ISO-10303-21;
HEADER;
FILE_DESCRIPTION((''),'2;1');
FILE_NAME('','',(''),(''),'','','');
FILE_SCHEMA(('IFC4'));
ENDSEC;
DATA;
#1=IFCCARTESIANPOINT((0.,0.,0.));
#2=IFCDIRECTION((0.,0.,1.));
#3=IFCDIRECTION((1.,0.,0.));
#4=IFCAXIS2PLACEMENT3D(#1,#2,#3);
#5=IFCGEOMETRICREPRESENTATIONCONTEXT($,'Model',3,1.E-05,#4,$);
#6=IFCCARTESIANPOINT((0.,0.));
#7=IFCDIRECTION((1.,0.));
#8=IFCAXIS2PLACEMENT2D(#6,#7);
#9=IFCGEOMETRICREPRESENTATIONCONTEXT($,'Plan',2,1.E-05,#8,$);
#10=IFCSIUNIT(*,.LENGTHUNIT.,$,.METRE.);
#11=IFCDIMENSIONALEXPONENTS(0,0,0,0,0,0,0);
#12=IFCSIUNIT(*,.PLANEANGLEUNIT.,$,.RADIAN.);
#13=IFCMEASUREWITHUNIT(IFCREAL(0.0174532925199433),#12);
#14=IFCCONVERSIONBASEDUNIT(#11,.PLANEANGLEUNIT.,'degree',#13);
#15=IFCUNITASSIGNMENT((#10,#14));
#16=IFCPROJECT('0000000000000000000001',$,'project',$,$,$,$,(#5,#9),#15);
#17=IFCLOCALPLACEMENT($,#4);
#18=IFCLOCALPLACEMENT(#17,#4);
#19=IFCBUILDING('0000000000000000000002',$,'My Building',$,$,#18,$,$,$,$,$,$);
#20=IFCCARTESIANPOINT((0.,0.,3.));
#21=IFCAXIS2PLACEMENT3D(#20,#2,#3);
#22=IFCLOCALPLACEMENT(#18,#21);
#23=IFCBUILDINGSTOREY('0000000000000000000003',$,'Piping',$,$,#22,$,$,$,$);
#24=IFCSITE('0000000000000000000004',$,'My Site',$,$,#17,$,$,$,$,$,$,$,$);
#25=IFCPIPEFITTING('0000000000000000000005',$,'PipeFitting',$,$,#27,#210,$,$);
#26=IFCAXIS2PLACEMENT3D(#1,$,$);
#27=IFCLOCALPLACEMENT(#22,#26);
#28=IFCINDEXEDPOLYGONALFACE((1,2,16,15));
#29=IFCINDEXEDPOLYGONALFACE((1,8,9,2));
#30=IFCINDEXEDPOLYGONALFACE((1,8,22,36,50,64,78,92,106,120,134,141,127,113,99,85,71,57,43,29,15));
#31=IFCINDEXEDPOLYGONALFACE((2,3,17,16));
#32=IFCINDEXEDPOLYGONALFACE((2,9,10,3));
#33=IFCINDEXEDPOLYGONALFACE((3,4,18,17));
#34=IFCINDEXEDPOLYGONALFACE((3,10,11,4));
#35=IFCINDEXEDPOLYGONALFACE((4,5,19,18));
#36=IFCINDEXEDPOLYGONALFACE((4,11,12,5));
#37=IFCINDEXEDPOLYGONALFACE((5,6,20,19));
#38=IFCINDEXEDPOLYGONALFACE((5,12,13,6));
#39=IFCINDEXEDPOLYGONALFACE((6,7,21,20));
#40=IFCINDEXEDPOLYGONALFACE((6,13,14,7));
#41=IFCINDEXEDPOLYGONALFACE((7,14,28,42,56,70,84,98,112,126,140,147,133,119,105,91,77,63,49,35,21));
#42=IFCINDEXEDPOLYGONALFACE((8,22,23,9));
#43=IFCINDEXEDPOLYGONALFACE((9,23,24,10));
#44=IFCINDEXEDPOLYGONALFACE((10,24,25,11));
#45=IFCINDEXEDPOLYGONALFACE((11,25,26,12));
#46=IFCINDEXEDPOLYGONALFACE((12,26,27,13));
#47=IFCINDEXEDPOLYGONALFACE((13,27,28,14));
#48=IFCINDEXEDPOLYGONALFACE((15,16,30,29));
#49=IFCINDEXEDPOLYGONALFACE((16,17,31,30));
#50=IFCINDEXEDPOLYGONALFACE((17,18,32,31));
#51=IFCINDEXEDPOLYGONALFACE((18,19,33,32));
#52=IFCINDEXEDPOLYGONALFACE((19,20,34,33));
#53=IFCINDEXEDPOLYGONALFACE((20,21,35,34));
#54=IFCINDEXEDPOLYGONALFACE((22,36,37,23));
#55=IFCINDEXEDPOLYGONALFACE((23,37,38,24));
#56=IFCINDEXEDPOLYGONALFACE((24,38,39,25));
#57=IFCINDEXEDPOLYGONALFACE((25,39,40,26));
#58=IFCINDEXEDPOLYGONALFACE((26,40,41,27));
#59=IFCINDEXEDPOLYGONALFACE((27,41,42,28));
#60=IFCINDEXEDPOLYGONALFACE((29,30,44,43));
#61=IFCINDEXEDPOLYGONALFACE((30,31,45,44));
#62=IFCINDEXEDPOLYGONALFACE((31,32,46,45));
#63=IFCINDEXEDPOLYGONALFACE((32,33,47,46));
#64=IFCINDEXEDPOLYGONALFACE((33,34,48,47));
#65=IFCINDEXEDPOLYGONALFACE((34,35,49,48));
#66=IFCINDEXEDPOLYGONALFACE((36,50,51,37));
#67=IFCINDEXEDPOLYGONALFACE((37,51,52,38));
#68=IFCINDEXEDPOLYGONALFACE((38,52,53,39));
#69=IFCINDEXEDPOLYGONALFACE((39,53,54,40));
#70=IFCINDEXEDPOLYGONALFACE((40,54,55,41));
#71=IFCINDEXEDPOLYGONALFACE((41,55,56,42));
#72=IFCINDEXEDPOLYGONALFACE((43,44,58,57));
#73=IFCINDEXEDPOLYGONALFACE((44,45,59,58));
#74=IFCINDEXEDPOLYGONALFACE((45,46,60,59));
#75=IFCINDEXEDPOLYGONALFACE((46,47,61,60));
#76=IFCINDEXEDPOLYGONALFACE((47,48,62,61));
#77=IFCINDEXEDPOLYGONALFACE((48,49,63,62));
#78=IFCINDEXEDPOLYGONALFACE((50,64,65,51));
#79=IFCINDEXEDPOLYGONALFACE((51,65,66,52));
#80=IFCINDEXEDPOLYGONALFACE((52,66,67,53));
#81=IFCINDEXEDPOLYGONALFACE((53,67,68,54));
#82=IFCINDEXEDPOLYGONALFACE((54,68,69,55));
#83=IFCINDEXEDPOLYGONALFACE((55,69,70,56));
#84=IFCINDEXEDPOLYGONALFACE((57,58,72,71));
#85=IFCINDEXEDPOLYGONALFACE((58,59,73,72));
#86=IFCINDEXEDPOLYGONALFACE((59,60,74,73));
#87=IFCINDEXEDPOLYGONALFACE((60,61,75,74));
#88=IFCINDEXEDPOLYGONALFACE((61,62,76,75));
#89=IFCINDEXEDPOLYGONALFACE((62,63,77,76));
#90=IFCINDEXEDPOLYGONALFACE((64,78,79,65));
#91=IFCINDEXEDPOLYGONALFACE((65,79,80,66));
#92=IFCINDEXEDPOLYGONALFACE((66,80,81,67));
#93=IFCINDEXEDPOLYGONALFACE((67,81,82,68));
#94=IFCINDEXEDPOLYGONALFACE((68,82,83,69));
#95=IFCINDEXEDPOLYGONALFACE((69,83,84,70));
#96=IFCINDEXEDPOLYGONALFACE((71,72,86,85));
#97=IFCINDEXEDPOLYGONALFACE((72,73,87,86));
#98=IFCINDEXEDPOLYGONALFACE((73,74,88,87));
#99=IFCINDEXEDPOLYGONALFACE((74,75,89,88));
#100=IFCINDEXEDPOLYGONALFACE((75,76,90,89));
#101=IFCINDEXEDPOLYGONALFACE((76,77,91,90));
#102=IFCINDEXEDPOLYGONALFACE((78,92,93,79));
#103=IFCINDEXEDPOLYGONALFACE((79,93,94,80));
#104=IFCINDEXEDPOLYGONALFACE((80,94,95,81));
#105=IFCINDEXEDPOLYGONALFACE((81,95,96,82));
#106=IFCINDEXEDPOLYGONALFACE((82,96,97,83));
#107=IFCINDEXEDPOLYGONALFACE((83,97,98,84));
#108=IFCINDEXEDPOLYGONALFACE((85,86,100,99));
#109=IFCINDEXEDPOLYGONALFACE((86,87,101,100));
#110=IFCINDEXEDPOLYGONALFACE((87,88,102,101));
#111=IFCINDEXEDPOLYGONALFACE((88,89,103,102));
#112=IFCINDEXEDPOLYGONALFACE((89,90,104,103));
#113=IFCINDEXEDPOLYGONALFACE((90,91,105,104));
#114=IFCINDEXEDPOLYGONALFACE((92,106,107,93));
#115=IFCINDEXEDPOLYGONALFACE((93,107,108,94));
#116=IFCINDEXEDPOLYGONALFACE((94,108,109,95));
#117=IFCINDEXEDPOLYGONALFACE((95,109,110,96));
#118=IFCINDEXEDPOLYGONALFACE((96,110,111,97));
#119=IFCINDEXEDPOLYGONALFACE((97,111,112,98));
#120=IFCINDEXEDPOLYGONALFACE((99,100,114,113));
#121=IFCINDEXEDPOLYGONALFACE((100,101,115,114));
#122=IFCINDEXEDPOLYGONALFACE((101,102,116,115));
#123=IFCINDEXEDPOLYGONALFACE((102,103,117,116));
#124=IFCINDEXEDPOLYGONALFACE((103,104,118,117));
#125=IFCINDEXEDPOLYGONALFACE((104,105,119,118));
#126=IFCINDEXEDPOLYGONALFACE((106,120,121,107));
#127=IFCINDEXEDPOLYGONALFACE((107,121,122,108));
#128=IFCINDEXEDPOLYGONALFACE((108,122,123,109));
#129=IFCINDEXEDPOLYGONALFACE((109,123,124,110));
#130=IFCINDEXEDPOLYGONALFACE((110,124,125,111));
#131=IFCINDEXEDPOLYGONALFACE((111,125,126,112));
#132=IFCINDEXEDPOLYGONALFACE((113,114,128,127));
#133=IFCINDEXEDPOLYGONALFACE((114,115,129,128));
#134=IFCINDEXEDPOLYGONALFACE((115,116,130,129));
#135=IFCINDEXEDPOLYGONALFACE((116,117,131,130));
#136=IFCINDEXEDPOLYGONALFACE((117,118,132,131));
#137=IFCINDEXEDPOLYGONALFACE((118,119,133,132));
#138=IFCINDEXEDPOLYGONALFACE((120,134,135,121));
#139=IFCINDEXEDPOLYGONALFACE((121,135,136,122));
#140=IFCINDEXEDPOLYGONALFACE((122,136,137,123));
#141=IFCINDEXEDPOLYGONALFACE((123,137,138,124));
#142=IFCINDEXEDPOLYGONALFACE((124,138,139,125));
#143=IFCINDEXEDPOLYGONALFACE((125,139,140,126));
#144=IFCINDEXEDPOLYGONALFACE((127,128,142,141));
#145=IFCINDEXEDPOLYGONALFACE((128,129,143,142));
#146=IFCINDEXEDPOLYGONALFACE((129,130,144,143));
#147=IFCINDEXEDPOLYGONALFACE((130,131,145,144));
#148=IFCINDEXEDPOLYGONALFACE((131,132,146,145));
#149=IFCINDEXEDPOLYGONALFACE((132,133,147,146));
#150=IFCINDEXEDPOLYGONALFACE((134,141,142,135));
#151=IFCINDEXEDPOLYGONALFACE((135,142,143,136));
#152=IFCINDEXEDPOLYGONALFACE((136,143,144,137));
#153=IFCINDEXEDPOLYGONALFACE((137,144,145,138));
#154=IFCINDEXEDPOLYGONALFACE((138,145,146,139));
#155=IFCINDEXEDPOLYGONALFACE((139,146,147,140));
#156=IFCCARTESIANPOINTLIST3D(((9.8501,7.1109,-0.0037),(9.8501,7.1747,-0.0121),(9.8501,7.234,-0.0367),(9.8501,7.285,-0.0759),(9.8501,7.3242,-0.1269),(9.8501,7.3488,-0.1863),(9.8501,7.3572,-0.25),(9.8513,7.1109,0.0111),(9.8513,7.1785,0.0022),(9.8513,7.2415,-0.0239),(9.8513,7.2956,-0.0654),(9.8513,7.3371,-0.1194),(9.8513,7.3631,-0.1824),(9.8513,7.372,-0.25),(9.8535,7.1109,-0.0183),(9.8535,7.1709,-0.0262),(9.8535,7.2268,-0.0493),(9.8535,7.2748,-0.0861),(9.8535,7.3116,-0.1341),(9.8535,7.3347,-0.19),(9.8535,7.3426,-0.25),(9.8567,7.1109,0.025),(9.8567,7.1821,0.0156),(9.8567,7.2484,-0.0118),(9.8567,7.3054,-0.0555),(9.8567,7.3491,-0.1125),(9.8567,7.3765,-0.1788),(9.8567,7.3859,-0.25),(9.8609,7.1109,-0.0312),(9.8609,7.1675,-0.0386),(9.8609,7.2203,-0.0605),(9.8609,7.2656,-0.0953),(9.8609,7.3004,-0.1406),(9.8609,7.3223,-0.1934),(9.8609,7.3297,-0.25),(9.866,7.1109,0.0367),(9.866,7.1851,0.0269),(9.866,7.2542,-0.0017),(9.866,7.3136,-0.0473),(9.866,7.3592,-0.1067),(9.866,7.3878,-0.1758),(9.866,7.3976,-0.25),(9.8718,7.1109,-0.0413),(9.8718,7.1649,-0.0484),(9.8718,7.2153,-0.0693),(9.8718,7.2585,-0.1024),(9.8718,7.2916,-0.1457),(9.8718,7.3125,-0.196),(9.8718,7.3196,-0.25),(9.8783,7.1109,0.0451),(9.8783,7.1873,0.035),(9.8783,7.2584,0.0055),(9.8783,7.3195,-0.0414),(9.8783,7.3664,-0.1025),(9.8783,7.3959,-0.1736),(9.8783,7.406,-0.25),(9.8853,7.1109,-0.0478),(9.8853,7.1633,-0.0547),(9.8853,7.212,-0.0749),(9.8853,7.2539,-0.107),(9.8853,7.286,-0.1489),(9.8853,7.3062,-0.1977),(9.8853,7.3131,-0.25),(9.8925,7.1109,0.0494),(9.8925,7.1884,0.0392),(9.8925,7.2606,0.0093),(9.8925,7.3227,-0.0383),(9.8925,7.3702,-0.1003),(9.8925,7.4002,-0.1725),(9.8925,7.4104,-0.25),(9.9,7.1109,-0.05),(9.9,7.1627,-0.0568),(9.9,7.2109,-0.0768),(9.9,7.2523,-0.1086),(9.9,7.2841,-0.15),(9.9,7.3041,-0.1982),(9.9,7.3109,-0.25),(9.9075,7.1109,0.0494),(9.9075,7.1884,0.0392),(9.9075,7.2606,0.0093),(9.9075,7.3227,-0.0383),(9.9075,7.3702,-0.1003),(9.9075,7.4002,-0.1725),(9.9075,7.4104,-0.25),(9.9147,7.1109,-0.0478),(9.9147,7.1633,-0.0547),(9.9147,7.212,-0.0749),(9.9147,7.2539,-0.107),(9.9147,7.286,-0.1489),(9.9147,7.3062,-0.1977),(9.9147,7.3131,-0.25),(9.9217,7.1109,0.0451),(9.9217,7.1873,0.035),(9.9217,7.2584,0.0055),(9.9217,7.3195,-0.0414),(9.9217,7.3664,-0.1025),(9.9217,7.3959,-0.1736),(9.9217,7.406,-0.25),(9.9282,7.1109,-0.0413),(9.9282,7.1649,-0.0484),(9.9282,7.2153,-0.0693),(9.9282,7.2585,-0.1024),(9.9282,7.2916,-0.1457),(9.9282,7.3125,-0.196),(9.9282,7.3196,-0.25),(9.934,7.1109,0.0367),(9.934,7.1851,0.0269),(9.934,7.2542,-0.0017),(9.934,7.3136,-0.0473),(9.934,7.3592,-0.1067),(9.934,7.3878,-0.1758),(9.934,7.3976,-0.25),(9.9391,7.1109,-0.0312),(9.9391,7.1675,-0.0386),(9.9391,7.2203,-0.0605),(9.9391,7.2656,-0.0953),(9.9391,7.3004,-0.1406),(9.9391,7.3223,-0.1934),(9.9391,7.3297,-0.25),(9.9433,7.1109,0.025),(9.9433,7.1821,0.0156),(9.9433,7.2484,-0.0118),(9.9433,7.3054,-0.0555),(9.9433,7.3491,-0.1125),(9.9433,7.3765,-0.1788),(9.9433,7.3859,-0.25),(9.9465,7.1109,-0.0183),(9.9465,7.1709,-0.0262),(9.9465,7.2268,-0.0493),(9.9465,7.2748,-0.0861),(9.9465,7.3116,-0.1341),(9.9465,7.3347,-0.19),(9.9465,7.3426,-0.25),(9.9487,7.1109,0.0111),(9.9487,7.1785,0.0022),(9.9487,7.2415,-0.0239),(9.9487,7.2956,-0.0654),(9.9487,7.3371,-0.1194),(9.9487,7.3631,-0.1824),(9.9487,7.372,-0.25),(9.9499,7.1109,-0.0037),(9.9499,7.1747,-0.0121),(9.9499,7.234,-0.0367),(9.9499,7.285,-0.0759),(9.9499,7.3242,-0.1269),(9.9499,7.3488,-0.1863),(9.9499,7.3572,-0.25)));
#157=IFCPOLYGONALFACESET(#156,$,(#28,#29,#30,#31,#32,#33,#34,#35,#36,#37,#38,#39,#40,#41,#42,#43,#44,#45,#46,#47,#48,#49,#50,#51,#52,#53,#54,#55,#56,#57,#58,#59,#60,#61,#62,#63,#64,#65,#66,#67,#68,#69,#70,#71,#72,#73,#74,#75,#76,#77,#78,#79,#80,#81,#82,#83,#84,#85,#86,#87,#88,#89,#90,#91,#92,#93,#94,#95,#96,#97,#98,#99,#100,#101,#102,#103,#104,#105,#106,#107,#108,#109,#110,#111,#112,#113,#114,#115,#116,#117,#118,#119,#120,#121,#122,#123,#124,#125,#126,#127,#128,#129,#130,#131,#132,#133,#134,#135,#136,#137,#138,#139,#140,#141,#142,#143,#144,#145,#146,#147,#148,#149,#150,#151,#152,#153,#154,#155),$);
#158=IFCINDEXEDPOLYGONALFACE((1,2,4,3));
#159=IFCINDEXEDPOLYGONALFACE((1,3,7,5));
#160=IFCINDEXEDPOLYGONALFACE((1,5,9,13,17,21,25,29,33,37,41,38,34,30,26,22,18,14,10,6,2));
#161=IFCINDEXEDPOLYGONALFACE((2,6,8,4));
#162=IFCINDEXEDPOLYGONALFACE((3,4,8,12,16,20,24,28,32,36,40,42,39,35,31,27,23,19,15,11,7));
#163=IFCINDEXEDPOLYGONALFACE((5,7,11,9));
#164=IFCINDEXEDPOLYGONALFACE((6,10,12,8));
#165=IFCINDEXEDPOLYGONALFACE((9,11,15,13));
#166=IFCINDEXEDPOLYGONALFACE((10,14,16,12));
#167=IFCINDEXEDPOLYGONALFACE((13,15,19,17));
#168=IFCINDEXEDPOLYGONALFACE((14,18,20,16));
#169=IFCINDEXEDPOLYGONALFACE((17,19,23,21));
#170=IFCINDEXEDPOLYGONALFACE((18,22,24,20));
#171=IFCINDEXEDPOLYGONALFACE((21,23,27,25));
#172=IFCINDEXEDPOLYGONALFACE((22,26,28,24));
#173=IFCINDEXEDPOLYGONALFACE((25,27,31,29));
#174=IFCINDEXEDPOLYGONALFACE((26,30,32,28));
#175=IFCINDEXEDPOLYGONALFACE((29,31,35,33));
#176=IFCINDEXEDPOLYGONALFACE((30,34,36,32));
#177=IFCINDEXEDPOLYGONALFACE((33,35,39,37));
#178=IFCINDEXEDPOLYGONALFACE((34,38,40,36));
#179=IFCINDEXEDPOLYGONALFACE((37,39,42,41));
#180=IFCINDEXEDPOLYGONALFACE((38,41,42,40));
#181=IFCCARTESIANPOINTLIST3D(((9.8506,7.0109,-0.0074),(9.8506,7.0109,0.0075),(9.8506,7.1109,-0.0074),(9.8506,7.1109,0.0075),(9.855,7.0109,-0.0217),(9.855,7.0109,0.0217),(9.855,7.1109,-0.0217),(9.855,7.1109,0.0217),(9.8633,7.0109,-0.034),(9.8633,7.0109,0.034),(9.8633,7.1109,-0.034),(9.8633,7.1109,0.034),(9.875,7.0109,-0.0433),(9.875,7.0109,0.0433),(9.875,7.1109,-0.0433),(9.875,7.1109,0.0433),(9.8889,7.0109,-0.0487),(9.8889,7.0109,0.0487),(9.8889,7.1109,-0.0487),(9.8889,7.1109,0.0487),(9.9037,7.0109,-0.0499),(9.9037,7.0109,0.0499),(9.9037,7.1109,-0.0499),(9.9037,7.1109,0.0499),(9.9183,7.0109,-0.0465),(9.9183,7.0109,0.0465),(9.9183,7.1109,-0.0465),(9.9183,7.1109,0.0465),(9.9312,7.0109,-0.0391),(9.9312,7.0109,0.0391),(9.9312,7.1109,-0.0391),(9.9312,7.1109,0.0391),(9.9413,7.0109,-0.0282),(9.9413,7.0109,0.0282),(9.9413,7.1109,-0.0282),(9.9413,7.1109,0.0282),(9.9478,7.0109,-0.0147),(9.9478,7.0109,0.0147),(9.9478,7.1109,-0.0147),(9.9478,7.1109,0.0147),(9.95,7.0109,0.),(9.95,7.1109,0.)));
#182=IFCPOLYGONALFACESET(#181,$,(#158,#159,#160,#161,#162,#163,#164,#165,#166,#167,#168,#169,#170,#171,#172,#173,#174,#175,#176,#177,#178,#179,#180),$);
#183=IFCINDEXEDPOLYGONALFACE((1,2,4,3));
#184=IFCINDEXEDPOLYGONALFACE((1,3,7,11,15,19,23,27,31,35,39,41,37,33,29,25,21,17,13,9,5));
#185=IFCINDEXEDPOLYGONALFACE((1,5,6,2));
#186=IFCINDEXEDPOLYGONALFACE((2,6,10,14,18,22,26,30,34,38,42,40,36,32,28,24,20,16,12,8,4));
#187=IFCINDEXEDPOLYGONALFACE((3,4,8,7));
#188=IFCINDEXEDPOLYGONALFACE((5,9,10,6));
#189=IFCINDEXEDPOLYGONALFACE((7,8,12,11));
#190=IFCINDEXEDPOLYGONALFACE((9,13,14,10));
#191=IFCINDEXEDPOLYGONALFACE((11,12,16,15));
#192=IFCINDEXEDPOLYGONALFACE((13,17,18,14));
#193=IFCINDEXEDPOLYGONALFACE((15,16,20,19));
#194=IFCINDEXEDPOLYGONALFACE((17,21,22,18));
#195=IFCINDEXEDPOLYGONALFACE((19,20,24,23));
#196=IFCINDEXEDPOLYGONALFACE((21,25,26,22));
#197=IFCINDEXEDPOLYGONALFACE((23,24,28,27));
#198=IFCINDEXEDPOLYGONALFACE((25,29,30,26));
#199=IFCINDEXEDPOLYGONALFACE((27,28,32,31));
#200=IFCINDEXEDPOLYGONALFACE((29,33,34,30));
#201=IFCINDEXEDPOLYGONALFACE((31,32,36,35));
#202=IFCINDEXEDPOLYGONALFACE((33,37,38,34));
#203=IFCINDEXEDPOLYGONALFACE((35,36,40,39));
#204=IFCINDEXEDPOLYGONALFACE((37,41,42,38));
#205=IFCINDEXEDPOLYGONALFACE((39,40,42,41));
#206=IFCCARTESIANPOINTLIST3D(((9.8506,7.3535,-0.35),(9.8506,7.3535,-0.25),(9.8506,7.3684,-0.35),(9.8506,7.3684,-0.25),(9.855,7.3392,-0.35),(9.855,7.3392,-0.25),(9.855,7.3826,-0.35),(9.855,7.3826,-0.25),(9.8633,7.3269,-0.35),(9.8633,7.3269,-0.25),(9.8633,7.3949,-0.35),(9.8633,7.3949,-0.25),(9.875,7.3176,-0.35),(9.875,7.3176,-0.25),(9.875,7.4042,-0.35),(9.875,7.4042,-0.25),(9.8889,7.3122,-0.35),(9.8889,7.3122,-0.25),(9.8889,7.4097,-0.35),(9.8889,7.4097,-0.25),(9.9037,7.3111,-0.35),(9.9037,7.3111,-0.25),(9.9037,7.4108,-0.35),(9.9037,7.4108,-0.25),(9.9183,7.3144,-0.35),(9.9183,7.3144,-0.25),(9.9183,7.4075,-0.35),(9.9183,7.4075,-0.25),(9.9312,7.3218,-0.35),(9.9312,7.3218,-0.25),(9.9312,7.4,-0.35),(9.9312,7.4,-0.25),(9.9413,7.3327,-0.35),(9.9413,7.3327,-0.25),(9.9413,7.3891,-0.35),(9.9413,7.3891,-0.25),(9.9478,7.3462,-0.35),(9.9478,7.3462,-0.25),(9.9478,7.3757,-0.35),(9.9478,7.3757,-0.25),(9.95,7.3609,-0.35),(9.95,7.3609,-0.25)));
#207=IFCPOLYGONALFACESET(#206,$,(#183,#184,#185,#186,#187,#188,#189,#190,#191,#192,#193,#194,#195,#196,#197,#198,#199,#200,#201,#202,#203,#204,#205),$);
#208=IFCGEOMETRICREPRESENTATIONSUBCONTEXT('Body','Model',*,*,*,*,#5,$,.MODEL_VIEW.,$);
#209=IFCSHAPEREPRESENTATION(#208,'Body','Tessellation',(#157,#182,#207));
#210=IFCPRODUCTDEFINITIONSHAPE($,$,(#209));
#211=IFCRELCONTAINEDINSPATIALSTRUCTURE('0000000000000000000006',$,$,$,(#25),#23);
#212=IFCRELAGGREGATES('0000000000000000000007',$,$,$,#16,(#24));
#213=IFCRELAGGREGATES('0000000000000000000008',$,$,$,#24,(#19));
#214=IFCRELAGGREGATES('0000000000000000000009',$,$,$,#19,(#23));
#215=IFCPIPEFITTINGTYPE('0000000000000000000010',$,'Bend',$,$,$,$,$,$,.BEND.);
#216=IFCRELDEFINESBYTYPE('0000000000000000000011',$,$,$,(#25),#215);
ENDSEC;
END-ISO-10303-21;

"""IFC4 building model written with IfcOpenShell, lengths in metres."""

from ifc_helpers import new_model, entity, si_unit, converted_unit, frame, origin_with_axes, origin_2d_with_axis, place, context, subcontext, project, spatial, circle, extrude, source, transform, mapped, type_object, type_shapes, element, save


model = new_model("IFC4")

# Units and contexts
model_context = context("Model", 3, precision=1e-05, world=origin_with_axes())
plan_context = context("Plan", 2, precision=1e-05, world=origin_2d_with_axis())
body_context = subcontext(model_context, "Body", "Model", "MODEL_VIEW")
ifc_project = project(units=[si_unit("LENGTHUNIT", "METRE"), converted_unit("PLANEANGLEUNIT", "degree", entity("IfcReal", 0.0174532925199433), si_unit("PLANEANGLEUNIT", "RADIAN"), dimensions=[0, 0, 0, 0, 0, 0, 0])], contexts=[model_context, plan_context])

# Site, building, storey
site_placement = place(None, origin_with_axes())
site = spatial("IfcSite", under=ifc_project, at=site_placement, Name="My Site")
building_placement = place(site_placement, origin_with_axes())
building = spatial("IfcBuilding", under=site, at=building_placement, Name="My Building")
storey_placement = place(building_placement, frame((0.0, 0.0, 3.0), z_axis=(0.0, 0.0, 1.0), x_axis=(1.0, 0.0, 0.0)))
storey = spatial("IfcBuildingStorey", under=building, at=storey_placement, Name="Piping")

# Pipe fitting
pipe_fitting_type = type_object("IfcPipeFittingType", Name="Bend", PredefinedType="BEND")
shared_shape = source(origin_with_axes(), body_context, "Body", "SolidModel", [
    entity("IfcSweptDiskSolid", entity("IfcIndexedPolyCurve", entity("IfcCartesianPointList3D", [[0.0, 0.0, -0.1], [0.0, -0.0732, -0.2768], [0.0, -0.25, -0.35]]), [entity("IfcArcIndex", [1, 2, 3])]), 0.05),
    extrude(circle(Radius=0.05), origin_with_axes(), (0.0, 0.0, -1.0), 0.1),
    extrude(circle(Radius=0.05), frame((0.0, -0.25, -0.35), z_axis=(0.0, -1.0, 0.0), x_axis=(1.0, 0.0, 0.0)), (0.0, 0.0, 1.0), 0.1),
])
type_shapes(pipe_fitting_type, [shared_shape])
for number, where, z_axis, x_axis, name in (
    (1, (9.9, 7.0109, 0.0), (0.0, -1.0, 0.0), (1.0, 0.0, 0.0), "PipeFitting"),
):
    element("IfcPipeFitting", number, at=place(storey_placement, frame(where, z_axis=z_axis, x_axis=x_axis)), inside=storey, type_object=pipe_fitting_type, Name=name, context=body_context, shape_type="MappedRepresentation", body=[
        mapped(shared_shape, transform((0.0, 0.0, 0.0), x_axis=(1.0, 0.0, 0.0), y_axis=(0.0, 1.0, 0.0), z_axis=(0.0, 0.0, 1.0), scale=1.0)),
    ])

save(model, "model.ifc")
